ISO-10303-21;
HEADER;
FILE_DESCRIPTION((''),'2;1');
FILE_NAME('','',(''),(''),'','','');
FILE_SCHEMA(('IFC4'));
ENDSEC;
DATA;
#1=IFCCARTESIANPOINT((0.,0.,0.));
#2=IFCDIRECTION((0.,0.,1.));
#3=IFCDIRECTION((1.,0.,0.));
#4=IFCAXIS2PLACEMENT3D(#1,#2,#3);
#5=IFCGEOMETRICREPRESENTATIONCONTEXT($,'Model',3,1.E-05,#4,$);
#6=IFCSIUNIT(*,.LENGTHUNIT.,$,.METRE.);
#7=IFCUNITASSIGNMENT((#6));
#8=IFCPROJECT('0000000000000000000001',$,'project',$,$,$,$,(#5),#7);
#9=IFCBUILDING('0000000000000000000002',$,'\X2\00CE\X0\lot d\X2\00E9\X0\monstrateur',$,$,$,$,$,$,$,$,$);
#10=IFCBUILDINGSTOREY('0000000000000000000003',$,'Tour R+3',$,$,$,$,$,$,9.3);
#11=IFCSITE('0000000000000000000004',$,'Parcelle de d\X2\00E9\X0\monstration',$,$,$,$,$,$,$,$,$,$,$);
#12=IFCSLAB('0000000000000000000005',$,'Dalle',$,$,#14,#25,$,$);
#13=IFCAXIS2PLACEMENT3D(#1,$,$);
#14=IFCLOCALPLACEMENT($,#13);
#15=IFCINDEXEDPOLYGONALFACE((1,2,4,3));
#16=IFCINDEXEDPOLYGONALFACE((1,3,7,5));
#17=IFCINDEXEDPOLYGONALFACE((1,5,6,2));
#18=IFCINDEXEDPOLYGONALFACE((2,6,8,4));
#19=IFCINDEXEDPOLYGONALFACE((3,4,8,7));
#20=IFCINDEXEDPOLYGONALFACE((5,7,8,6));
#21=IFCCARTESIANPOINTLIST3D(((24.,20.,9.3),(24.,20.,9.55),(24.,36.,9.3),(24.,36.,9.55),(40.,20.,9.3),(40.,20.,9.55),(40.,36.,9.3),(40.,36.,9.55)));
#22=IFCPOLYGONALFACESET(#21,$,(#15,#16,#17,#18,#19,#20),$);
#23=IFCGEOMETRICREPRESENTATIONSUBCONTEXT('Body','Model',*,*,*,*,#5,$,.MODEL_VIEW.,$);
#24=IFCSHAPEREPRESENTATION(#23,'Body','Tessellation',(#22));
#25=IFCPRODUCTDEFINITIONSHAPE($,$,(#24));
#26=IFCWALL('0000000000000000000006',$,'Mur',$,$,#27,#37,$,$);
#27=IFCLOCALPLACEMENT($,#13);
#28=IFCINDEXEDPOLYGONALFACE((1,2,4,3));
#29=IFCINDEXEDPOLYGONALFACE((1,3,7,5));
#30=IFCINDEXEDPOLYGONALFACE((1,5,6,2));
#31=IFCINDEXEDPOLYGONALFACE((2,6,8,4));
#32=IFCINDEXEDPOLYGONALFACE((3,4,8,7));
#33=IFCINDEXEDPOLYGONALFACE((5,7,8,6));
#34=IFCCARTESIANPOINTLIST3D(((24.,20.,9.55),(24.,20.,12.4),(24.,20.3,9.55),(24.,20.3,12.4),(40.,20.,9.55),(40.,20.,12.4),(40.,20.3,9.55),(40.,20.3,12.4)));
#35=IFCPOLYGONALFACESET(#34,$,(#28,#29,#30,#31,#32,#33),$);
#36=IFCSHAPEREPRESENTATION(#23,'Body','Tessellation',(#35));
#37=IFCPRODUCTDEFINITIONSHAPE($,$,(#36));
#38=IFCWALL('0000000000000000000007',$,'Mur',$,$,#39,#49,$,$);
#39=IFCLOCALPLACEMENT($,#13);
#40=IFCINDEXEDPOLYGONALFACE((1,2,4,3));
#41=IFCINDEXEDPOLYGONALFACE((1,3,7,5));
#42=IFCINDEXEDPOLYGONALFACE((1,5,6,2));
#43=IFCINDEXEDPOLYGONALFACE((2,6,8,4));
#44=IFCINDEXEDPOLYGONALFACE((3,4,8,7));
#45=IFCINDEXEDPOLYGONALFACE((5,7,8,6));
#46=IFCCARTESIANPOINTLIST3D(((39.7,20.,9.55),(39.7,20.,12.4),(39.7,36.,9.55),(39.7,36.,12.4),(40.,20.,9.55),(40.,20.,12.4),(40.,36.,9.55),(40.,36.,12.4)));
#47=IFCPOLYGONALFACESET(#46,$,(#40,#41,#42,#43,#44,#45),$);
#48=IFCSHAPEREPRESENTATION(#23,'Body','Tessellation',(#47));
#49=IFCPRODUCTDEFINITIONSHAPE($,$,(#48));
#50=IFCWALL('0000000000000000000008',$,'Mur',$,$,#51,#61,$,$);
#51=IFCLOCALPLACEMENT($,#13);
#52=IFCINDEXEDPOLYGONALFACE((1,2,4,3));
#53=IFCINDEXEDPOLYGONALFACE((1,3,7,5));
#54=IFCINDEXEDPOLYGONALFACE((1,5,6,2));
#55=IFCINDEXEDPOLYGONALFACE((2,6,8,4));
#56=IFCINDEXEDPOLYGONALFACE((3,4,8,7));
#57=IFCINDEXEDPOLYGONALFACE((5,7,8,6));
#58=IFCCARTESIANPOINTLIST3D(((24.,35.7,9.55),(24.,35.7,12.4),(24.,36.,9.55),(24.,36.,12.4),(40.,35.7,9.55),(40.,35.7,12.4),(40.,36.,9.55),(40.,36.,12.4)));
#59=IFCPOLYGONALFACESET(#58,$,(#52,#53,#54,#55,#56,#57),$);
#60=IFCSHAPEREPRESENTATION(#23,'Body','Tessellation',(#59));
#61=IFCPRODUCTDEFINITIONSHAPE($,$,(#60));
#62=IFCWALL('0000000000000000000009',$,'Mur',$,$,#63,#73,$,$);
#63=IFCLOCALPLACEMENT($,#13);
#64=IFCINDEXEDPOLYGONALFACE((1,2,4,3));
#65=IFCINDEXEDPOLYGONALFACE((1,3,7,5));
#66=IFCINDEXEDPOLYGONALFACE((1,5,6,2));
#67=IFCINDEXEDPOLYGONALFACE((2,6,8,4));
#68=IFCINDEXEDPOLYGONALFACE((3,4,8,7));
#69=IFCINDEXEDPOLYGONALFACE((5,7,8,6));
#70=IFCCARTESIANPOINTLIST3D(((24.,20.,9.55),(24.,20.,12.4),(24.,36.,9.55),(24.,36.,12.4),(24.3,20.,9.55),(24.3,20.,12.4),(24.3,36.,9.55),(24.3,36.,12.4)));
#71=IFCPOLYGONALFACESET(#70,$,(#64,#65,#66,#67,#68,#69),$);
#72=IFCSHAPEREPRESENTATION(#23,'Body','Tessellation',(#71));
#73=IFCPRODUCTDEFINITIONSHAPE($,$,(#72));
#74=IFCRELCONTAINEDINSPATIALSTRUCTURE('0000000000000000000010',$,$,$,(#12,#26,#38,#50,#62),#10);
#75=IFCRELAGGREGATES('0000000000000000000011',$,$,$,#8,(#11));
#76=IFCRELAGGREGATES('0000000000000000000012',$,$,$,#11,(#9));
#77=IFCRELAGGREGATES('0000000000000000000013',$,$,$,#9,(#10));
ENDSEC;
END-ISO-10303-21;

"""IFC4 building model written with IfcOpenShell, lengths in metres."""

from ifc_helpers import new_model, si_unit, frame, origin_with_axes, place, context, subcontext, project, spatial, indexed_curve, outline, extrude, element, save


model = new_model("IFC4")

# Units and contexts
model_context = context("Model", 3, precision=1e-05, world=origin_with_axes())
body_context = subcontext(model_context, "Body", "Model", "MODEL_VIEW")
ifc_project = project(units=[si_unit("LENGTHUNIT", "METRE")], contexts=[model_context])

# Site, building, storey
site = spatial("IfcSite", under=ifc_project, Name="Parcelle de démonstration")
building = spatial("IfcBuilding", under=site, Name="Îlot démonstrateur")
storey = spatial("IfcBuildingStorey", under=building, Name="Tour R+3", Elevation=9.3)

# Slab
slab_placement = place(None, frame((0.0, 0.0, 9.3), z_axis=(0.0, 0.0, 1.0), x_axis=(1.0, 0.0, 0.0)))
element("IfcSlab", 1, at=slab_placement, inside=storey, Name="Dalle", context=body_context, shape_type="SweptSolid", body=[
    extrude(outline(indexed_curve([(24.0, 20.0), (40.0, 20.0), (40.0, 36.0), (24.0, 36.0)])), None, (0.0, 0.0, 1.0), 0.25),
])

# Walls
for number, where, z_axis, x_axis, name in (
    (2, (24.0, 20.0, 9.55), (0.0, 0.0, 1.0), (1.0, 0.0, 0.0), "Mur"),
    (3, (40.0, 20.0, 9.55), (0.0, 0.0, 1.0), (0.0, 1.0, 0.0), "Mur"),
    (4, (40.0, 36.0, 9.55), (0.0, 0.0, 1.0), (-1.0, 0.0, 0.0), "Mur"),
    (5, (24.0, 36.0, 9.55), (0.0, 0.0, 1.0), (0.0, -1.0, 0.0), "Mur"),
):
    element("IfcWall", number, at=place(None, frame(where, z_axis=z_axis, x_axis=x_axis)), inside=storey, Name=name, context=body_context, shape_type="SweptSolid", body=[
        extrude(outline(indexed_curve([(0.0, 0.0), (0.0, 0.3), (16.0, 0.3), (16.0, 0.0), (0.0, 0.0)], self_intersect=False)), origin_with_axes(), (0.0, 0.0, 1.0), 2.85),
    ])

save(model, "model.ifc")
